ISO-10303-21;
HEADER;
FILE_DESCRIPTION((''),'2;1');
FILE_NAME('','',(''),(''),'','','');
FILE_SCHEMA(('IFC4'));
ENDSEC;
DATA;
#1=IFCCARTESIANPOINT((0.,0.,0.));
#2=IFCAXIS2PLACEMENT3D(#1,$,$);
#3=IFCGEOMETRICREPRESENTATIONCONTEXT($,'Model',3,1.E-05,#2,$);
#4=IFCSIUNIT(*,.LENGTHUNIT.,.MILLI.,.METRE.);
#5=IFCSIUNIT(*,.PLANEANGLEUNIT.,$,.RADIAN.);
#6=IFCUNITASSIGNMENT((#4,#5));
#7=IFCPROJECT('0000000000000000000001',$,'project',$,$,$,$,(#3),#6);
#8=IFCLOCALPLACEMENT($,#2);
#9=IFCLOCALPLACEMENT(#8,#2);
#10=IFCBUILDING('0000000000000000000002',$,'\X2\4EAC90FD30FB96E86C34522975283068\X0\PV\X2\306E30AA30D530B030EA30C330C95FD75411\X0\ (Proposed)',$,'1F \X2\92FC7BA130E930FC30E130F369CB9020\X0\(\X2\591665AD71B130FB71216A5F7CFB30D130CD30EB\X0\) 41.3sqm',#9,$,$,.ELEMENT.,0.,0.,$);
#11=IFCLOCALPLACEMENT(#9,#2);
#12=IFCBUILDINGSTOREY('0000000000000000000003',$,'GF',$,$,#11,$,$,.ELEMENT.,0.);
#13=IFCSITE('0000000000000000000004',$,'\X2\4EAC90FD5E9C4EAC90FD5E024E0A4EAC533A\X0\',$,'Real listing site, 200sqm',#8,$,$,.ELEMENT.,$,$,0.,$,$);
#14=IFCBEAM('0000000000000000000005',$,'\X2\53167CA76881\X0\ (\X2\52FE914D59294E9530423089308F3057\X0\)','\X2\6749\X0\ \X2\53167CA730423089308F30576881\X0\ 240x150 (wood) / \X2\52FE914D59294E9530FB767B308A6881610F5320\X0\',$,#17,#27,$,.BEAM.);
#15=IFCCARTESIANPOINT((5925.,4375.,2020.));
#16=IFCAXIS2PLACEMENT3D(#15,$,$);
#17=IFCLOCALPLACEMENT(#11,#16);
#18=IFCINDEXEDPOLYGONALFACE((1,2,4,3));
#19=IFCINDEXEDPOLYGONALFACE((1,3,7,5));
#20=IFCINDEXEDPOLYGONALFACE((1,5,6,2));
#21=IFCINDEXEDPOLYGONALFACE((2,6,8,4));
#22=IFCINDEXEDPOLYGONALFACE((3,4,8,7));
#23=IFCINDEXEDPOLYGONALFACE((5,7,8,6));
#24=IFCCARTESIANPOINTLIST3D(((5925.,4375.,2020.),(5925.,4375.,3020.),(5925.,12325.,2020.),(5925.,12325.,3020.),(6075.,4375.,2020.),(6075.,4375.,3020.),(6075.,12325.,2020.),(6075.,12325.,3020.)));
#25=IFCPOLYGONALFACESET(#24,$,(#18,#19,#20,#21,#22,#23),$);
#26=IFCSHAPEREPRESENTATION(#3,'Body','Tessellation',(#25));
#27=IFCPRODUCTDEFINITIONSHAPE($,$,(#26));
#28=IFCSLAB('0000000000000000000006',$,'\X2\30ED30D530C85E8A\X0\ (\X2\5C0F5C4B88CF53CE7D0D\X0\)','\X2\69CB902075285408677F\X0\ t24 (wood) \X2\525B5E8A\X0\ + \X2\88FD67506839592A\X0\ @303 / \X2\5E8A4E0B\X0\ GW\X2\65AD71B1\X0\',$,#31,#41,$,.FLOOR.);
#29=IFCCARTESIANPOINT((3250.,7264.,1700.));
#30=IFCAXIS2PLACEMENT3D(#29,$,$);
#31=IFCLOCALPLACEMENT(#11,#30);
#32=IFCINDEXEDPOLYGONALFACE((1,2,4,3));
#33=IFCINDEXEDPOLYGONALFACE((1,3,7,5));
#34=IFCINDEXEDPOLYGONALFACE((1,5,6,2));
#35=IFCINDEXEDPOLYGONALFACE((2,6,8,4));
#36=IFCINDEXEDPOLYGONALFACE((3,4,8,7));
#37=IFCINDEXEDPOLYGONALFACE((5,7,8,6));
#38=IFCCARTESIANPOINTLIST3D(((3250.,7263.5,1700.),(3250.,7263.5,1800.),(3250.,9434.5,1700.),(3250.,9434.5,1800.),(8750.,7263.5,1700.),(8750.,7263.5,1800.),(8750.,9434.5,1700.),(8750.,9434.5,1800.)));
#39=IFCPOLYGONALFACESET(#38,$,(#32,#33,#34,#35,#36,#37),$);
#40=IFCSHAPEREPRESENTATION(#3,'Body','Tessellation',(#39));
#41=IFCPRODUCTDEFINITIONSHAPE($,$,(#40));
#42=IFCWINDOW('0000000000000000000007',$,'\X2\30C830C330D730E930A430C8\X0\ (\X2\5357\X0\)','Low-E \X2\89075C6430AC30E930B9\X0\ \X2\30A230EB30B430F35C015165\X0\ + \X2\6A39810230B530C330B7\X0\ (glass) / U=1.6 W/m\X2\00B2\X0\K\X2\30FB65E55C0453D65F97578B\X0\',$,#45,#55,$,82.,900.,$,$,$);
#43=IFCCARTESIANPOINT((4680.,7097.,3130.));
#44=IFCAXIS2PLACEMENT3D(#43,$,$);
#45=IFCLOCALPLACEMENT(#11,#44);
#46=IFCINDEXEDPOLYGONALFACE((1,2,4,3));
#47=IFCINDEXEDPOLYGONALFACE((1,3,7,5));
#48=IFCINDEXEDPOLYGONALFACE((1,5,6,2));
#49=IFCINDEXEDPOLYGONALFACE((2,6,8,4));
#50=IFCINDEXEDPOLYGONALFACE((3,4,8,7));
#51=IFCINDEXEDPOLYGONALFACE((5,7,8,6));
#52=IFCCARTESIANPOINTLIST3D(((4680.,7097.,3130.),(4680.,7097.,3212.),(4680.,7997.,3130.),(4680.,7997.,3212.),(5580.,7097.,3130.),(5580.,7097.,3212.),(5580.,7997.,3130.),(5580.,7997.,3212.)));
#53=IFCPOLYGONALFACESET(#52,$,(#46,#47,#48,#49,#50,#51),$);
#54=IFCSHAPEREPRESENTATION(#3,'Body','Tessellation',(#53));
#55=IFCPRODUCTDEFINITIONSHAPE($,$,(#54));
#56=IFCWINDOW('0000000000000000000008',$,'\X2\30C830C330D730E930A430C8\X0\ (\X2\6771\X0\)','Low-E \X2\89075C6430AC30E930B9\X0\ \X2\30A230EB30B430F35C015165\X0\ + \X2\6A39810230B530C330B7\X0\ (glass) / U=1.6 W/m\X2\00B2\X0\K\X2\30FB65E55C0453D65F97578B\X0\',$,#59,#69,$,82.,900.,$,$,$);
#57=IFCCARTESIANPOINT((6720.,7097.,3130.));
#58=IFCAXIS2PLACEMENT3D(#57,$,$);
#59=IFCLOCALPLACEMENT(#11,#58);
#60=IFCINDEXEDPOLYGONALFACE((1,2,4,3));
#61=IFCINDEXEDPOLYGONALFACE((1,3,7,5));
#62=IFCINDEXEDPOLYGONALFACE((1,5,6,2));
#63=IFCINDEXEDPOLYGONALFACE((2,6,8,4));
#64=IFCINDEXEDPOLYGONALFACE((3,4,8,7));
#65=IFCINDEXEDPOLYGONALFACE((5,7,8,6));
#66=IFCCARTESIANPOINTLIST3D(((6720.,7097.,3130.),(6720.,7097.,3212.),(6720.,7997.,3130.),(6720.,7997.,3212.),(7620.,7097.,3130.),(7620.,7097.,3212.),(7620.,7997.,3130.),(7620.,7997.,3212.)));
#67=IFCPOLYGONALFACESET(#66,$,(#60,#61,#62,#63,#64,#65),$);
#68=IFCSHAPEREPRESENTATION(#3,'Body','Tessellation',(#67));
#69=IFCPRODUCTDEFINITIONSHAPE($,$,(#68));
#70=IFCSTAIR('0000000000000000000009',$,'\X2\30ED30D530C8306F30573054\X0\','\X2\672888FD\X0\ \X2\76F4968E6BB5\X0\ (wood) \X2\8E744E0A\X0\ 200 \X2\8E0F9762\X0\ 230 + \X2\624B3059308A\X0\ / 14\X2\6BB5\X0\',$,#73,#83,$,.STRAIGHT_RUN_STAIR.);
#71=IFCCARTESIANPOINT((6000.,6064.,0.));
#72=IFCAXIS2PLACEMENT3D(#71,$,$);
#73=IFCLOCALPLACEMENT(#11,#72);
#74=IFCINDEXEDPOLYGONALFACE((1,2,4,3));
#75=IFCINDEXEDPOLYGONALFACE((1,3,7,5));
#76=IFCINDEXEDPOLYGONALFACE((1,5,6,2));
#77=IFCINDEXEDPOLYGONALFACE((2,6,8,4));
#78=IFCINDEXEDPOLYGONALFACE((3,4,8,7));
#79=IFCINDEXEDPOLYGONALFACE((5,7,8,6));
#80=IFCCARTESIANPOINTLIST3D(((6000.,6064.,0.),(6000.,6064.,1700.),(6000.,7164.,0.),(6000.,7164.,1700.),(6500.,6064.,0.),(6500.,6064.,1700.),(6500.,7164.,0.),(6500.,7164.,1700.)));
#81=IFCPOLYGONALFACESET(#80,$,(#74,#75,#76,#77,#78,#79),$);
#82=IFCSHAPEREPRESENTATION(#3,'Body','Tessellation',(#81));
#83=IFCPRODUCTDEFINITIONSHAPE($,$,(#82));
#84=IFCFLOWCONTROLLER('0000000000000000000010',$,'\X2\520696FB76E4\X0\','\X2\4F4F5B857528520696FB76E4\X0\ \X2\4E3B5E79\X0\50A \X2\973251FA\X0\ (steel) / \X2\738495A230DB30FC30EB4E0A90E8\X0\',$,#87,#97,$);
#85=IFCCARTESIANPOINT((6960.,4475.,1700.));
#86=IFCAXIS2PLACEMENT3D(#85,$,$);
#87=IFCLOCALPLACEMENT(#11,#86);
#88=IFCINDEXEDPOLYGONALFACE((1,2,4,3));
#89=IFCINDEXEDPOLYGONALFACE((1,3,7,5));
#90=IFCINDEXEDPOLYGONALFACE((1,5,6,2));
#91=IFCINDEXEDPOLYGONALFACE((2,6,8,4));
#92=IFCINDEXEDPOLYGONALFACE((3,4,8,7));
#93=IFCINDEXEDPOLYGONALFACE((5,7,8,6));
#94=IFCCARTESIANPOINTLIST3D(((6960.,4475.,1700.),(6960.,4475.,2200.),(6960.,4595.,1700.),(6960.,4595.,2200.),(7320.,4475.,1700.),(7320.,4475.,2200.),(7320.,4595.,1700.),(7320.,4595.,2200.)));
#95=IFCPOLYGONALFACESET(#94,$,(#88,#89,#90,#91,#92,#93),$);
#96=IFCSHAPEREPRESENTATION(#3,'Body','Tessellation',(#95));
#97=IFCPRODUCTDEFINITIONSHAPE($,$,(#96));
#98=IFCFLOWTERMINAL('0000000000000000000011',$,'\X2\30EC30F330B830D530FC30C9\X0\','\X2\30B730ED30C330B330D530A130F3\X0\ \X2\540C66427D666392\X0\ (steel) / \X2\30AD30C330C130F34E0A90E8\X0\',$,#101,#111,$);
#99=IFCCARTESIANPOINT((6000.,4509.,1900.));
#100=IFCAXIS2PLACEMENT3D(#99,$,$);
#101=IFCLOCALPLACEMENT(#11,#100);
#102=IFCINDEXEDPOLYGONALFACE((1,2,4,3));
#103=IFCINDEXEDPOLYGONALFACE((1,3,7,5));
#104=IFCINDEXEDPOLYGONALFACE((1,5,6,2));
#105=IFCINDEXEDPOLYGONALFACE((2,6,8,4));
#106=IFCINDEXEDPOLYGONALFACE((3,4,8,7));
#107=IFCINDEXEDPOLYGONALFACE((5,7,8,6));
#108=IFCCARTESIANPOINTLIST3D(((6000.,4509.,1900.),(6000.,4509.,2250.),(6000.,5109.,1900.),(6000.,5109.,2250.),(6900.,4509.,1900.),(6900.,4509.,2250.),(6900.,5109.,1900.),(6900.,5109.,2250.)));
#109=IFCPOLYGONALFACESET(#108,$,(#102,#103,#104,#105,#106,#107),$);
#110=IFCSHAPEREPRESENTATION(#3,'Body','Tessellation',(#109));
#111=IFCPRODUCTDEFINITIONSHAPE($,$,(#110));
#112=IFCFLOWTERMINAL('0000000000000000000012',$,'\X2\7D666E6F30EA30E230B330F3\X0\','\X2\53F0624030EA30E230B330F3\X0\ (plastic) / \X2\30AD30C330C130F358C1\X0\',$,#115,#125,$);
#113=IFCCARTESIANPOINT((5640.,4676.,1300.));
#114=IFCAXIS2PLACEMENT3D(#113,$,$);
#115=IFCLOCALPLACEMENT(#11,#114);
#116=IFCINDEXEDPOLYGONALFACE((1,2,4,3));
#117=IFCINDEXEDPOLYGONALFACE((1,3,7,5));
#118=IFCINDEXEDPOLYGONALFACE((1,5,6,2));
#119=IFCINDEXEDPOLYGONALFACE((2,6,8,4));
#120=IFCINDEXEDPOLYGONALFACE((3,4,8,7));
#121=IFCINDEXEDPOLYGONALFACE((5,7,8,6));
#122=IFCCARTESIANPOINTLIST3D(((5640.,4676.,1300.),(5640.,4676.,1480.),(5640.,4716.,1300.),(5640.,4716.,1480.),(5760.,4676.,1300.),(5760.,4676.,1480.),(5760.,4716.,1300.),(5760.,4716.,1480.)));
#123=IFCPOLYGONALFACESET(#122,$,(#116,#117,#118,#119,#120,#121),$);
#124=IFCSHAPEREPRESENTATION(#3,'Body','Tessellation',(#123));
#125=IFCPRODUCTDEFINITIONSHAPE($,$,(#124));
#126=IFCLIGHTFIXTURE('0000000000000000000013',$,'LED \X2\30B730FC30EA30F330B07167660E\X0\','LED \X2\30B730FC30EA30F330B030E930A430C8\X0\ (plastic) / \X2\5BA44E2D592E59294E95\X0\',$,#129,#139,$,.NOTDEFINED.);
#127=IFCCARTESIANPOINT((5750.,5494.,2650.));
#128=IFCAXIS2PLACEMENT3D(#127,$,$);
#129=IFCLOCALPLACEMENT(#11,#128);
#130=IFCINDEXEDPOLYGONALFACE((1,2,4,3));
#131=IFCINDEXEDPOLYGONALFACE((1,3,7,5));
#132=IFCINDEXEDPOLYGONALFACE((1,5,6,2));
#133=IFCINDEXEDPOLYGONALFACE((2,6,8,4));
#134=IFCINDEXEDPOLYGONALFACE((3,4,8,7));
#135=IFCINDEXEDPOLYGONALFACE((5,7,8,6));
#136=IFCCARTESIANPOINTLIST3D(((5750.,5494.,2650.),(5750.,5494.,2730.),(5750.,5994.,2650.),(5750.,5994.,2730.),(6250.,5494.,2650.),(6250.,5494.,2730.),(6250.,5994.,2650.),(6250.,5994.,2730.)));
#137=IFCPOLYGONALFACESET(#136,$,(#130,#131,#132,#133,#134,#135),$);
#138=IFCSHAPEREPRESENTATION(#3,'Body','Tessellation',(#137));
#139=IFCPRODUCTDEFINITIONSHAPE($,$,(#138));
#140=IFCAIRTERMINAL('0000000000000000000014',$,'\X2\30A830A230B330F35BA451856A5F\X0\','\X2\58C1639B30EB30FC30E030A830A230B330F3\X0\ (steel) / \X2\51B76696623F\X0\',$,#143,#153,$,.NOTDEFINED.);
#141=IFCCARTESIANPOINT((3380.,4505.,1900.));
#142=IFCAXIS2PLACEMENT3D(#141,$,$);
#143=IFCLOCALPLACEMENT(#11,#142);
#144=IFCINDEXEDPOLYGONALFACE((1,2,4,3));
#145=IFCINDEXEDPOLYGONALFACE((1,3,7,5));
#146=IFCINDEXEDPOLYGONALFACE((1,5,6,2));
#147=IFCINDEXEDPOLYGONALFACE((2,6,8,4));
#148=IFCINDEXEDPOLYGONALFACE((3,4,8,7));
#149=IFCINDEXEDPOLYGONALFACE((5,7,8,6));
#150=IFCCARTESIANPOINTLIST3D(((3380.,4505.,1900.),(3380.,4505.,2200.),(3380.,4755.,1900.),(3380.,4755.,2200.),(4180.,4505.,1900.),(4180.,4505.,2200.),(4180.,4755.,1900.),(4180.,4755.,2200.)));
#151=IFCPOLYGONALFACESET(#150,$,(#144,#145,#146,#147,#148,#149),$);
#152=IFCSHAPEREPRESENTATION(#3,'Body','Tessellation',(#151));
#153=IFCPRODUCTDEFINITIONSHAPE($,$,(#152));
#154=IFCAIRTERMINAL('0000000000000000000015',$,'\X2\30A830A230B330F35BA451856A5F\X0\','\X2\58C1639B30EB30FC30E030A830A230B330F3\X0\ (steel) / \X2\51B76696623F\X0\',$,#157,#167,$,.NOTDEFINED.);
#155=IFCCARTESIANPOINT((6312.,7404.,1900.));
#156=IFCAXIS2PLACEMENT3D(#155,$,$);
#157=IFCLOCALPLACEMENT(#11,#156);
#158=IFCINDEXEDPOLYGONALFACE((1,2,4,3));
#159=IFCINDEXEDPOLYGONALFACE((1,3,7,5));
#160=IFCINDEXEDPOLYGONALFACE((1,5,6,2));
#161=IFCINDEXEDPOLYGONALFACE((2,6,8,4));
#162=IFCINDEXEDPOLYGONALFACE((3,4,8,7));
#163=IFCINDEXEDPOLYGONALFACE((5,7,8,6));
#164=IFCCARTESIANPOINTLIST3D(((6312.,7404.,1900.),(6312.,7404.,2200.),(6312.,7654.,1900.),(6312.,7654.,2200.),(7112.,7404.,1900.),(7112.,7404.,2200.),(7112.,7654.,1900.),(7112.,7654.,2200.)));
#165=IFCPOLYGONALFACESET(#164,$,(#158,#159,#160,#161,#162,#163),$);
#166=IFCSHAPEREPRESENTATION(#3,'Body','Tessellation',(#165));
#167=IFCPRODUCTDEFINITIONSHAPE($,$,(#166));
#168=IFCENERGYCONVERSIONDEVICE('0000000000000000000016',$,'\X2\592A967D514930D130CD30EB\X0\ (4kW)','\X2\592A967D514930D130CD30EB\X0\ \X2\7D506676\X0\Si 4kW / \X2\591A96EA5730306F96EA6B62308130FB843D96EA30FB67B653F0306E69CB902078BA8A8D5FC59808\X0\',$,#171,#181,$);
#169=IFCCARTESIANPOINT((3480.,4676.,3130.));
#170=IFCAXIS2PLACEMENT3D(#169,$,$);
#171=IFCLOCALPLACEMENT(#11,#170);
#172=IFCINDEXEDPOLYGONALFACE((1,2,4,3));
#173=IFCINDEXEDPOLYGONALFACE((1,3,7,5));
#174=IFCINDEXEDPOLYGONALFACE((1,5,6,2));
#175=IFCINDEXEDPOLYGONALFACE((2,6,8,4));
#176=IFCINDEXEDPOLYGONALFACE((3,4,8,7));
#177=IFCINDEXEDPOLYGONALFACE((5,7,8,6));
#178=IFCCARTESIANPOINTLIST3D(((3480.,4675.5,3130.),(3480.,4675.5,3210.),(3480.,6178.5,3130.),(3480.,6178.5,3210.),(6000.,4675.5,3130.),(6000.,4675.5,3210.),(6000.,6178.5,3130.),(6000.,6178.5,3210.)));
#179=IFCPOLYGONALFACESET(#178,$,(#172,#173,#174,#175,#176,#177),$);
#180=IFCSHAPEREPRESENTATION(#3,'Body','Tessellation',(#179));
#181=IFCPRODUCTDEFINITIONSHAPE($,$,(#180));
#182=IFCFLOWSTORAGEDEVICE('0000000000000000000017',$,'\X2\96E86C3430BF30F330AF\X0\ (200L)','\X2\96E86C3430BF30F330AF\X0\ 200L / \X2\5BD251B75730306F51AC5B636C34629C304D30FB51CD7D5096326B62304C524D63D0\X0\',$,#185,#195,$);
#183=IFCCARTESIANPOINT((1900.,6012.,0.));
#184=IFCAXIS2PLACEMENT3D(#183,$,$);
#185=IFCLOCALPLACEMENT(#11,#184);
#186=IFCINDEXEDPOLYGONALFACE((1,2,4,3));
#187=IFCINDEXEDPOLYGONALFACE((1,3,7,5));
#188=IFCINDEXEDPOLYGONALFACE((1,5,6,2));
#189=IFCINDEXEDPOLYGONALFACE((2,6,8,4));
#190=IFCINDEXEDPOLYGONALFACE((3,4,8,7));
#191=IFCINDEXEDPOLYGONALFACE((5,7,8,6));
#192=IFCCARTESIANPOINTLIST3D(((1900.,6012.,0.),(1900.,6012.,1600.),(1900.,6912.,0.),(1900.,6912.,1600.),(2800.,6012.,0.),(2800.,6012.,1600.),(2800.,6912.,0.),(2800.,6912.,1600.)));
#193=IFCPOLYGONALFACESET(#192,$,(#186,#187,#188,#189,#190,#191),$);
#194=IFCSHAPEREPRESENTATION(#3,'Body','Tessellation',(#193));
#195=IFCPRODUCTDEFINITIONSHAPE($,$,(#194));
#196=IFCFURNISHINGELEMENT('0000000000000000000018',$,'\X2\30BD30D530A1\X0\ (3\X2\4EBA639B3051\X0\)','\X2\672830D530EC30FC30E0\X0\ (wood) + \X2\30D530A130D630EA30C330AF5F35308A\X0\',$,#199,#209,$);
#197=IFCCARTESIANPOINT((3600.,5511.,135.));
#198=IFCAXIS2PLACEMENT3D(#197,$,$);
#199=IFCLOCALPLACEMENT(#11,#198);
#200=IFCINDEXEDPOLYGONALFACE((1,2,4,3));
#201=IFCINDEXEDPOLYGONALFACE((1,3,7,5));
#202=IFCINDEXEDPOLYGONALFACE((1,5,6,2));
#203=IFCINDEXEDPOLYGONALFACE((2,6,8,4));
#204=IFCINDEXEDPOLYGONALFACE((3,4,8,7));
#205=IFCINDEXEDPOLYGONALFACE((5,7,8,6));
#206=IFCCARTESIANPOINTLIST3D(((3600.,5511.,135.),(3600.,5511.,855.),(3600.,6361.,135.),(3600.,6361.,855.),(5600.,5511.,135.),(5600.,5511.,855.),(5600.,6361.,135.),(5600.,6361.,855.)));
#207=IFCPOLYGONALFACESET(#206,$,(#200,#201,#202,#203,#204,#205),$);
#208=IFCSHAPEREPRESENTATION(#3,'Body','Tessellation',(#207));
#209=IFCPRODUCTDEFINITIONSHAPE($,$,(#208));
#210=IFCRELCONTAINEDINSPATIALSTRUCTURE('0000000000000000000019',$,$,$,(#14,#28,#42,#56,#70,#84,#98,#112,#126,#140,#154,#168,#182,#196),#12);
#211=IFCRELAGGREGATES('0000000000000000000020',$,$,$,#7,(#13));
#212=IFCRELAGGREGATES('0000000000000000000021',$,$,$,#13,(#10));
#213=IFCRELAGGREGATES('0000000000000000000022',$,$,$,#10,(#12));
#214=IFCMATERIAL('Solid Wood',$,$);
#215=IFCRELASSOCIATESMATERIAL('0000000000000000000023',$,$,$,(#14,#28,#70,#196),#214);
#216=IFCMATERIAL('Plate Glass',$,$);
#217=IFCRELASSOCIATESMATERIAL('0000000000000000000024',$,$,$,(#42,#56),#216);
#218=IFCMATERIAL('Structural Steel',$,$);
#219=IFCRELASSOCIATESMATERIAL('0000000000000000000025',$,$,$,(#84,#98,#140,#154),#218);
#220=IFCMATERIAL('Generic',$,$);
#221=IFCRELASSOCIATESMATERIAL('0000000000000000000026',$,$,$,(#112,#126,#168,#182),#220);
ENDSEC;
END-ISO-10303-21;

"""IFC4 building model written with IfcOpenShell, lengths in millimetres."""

from ifc_helpers import new_model, si_unit, frame, frame_2d, origin, place, context, project, spatial, rectangle, extrude, material, element, save


model = new_model("IFC4")

# Units and contexts
model_context = context("Model", 3, precision=1e-05, world=origin())
ifc_project = project(units=[si_unit("LENGTHUNIT", "METRE", prefix="MILLI"), si_unit("PLANEANGLEUNIT", "RADIAN")], contexts=[model_context])

# Site, building, storey
site_placement = place(None, origin())
site = spatial("IfcSite", under=ifc_project, at=site_placement, Name="京都府京都市上京区", ObjectType="Real listing site, 200sqm", CompositionType="ELEMENT", RefElevation=0.0)
building_placement = place(site_placement, origin())
building = spatial("IfcBuilding", under=site, at=building_placement, Name="京都・雨水利用とPVのオフグリッド志向 (Proposed)", ObjectType="1F 鋼管ラーメン構造(外断熱・無機系パネル) 41.3sqm", CompositionType="ELEMENT", ElevationOfRefHeight=0.0, ElevationOfTerrain=0.0)
storey_placement = place(building_placement, origin())
storey = spatial("IfcBuildingStorey", under=building, at=storey_placement, Name="GF", CompositionType="ELEMENT", Elevation=0.0)

# Shared definitions
ifc_material_1 = material(Name="Solid Wood")

# Beam
beam_placement = place(storey_placement, frame((5925.0, 4375.0, 2020.0)))
element("IfcBeam", 1, at=beam_placement, inside=storey, material=ifc_material_1, Name="化粧梁 (勾配天井あらわし)", Description="杉 化粧あらわし梁 240x150 (wood) / 勾配天井・登り梁意匠", PredefinedType="BEAM", context=model_context, shape_type="SweptSolid", body=[
    extrude(rectangle(XDim=150.0, YDim=7950.0, at=frame_2d((75.0, 3975.0))), frame((5925.0, 4375.0, 2020.0)), (0.0, 0.0, 1.0), 1000.0),
])

# Slab
slab_placement = place(storey_placement, frame((3250.0, 7264.0, 1700.0)))
element("IfcSlab", 2, at=slab_placement, inside=storey, material=ifc_material_1, Name="ロフト床 (小屋裏収納)", Description="構造用合板 t24 (wood) 剛床 + 製材根太 @303 / 床下 GW断熱", PredefinedType="FLOOR", context=model_context, shape_type="SweptSolid", body=[
    extrude(rectangle(XDim=5500.0, YDim=2171.0, at=frame_2d((2750.0, 1085.0))), frame((3250.0, 7264.0, 1700.0)), (0.0, 0.0, 1.0), 100.0),
])

# Windows
ifc_material_2 = material(Name="Plate Glass")
window_1_placement = place(storey_placement, frame((4680.0, 7097.0, 3130.0)))
element("IfcWindow", 3, at=window_1_placement, inside=storey, material=ifc_material_2, Name="トップライト (南)", Description="Low-E 複層ガラス アルゴン封入 + 樹脂サッシ (glass) / U=1.6 W/m²K・日射取得型", OverallHeight=82.0, OverallWidth=900.0, context=model_context, shape_type="SweptSolid", body=[
    extrude(rectangle(XDim=900.0, YDim=900.0, at=frame_2d((450.0, 450.0))), frame((4680.0, 7097.0, 3130.0)), (0.0, 0.0, 1.0), 82.0),
])
window_2_placement = place(storey_placement, frame((6720.0, 7097.0, 3130.0)))
element("IfcWindow", 4, at=window_2_placement, inside=storey, material=ifc_material_2, Name="トップライト (東)", Description="Low-E 複層ガラス アルゴン封入 + 樹脂サッシ (glass) / U=1.6 W/m²K・日射取得型", OverallHeight=82.0, OverallWidth=900.0, context=model_context, shape_type="SweptSolid", body=[
    extrude(rectangle(XDim=900.0, YDim=900.0, at=frame_2d((450.0, 450.0))), frame((6720.0, 7097.0, 3130.0)), (0.0, 0.0, 1.0), 82.0),
])

# Stair
stair_placement = place(storey_placement, frame((6000.0, 6064.0, 0.0)))
element("IfcStair", 5, at=stair_placement, inside=storey, material=ifc_material_1, Name="ロフトはしご", Description="木製 直階段 (wood) 蹴上 200 踏面 230 + 手すり / 14段", PredefinedType="STRAIGHT_RUN_STAIR", context=model_context, shape_type="SweptSolid", body=[
    extrude(rectangle(XDim=500.0, YDim=1100.0, at=frame_2d((250.0, 550.0))), frame((6000.0, 6064.0, 0.0)), (0.0, 0.0, 1.0), 1700.0),
])

# Flow controller
ifc_material_3 = material(Name="Structural Steel")
flow_controller_placement = place(storey_placement, frame((6960.0, 4475.0, 1700.0)))
element("IfcFlowController", 6, at=flow_controller_placement, inside=storey, material=ifc_material_3, Name="分電盤", Description="住宅用分電盤 主幹50A 露出 (steel) / 玄関ホール上部", context=model_context, shape_type="SweptSolid", body=[
    extrude(rectangle(XDim=360.0, YDim=120.0, at=frame_2d((180.0, 60.0))), frame((6960.0, 4475.0, 1700.0)), (0.0, 0.0, 1.0), 500.0),
])

# Flow terminals
flow_terminal_1_placement = place(storey_placement, frame((6000.0, 4509.0, 1900.0)))
element("IfcFlowTerminal", 7, at=flow_terminal_1_placement, inside=storey, material=ifc_material_3, Name="レンジフード", Description="シロッコファン 同時給排 (steel) / キッチン上部", context=model_context, shape_type="SweptSolid", body=[
    extrude(rectangle(XDim=900.0, YDim=600.0, at=frame_2d((450.0, 300.0))), frame((6000.0, 4509.0, 1900.0)), (0.0, 0.0, 1.0), 350.0),
])
ifc_material_4 = material(Name="Generic")
flow_terminal_2_placement = place(storey_placement, frame((5640.0, 4676.0, 1300.0)))
element("IfcFlowTerminal", 8, at=flow_terminal_2_placement, inside=storey, material=ifc_material_4, Name="給湯リモコン", Description="台所リモコン (plastic) / キッチン壁", context=model_context, shape_type="SweptSolid", body=[
    extrude(rectangle(XDim=120.0, YDim=40.0, at=frame_2d((60.0, 20.0))), frame((5640.0, 4676.0, 1300.0)), (0.0, 0.0, 1.0), 180.0),
])

# Light fixture
light_fixture_placement = place(storey_placement, frame((5750.0, 5494.0, 2650.0)))
element("IfcLightFixture", 9, at=light_fixture_placement, inside=storey, material=ifc_material_4, Name="LED シーリング照明", Description="LED シーリングライト (plastic) / 室中央天井", PredefinedType="NOTDEFINED", context=model_context, shape_type="SweptSolid", body=[
    extrude(rectangle(XDim=500.0, YDim=500.0, at=frame_2d((250.0, 250.0))), frame((5750.0, 5494.0, 2650.0)), (0.0, 0.0, 1.0), 80.0),
])

# Air terminals
air_terminal_1_placement = place(storey_placement, frame((3380.0, 4505.0, 1900.0)))
element("IfcAirTerminal", 10, at=air_terminal_1_placement, inside=storey, material=ifc_material_3, Name="エアコン室内機", Description="壁掛ルームエアコン (steel) / 冷暖房", PredefinedType="NOTDEFINED", context=model_context, shape_type="SweptSolid", body=[
    extrude(rectangle(XDim=800.0, YDim=250.0, at=frame_2d((400.0, 125.0))), frame((3380.0, 4505.0, 1900.0)), (0.0, 0.0, 1.0), 300.0),
])
air_terminal_2_placement = place(storey_placement, frame((6312.0, 7404.0, 1900.0)))
element("IfcAirTerminal", 11, at=air_terminal_2_placement, inside=storey, material=ifc_material_3, Name="エアコン室内機", Description="壁掛ルームエアコン (steel) / 冷暖房", PredefinedType="NOTDEFINED", context=model_context, shape_type="SweptSolid", body=[
    extrude(rectangle(XDim=800.0, YDim=250.0, at=frame_2d((400.0, 125.0))), frame((6312.0, 7404.0, 1900.0)), (0.0, 0.0, 1.0), 300.0),
])

# Energy conversion device
energy_conversion_device_placement = place(storey_placement, frame((3480.0, 4676.0, 3130.0)))
element("IfcEnergyConversionDevice", 12, at=energy_conversion_device_placement, inside=storey, material=ifc_material_4, Name="太陽光パネル (4kW)", Description="太陽光パネル 結晶Si 4kW / 多雪地は雪止め・落雪・架台の構造確認必須", context=model_context, shape_type="SweptSolid", body=[
    extrude(rectangle(XDim=2520.0, YDim=1503.0, at=frame_2d((1260.0, 751.0))), frame((3480.0, 4676.0, 3130.0)), (0.0, 0.0, 1.0), 80.0),
])

# Flow storage device
flow_storage_device_placement = place(storey_placement, frame((1900.0, 6012.0, 0.0)))
element("IfcFlowStorageDevice", 13, at=flow_storage_device_placement, inside=storey, material=ifc_material_4, Name="雨水タンク (200L)", Description="雨水タンク 200L / 寒冷地は冬季水抜き・凍結防止が前提", context=model_context, shape_type="SweptSolid", body=[
    extrude(rectangle(XDim=900.0, YDim=900.0, at=frame_2d((450.0, 450.0))), frame((1900.0, 6012.0, 0.0)), (0.0, 0.0, 1.0), 1600.0),
])

# Furnishing element
furnishing_1_placement = place(storey_placement, frame((3600.0, 5511.0, 135.0)))
element("IfcFurnishingElement", 14, at=furnishing_1_placement, inside=storey, material=ifc_material_1, Name="ソファ (3人掛け)", Description="木フレーム (wood) + ファブリック張り", context=model_context, shape_type="SweptSolid", body=[
    extrude(rectangle(XDim=2000.0, YDim=850.0, at=frame_2d((1000.0, 425.0))), frame((3600.0, 5511.0, 135.0)), (0.0, 0.0, 1.0), 720.0),
])

save(model, "model.ifc")
